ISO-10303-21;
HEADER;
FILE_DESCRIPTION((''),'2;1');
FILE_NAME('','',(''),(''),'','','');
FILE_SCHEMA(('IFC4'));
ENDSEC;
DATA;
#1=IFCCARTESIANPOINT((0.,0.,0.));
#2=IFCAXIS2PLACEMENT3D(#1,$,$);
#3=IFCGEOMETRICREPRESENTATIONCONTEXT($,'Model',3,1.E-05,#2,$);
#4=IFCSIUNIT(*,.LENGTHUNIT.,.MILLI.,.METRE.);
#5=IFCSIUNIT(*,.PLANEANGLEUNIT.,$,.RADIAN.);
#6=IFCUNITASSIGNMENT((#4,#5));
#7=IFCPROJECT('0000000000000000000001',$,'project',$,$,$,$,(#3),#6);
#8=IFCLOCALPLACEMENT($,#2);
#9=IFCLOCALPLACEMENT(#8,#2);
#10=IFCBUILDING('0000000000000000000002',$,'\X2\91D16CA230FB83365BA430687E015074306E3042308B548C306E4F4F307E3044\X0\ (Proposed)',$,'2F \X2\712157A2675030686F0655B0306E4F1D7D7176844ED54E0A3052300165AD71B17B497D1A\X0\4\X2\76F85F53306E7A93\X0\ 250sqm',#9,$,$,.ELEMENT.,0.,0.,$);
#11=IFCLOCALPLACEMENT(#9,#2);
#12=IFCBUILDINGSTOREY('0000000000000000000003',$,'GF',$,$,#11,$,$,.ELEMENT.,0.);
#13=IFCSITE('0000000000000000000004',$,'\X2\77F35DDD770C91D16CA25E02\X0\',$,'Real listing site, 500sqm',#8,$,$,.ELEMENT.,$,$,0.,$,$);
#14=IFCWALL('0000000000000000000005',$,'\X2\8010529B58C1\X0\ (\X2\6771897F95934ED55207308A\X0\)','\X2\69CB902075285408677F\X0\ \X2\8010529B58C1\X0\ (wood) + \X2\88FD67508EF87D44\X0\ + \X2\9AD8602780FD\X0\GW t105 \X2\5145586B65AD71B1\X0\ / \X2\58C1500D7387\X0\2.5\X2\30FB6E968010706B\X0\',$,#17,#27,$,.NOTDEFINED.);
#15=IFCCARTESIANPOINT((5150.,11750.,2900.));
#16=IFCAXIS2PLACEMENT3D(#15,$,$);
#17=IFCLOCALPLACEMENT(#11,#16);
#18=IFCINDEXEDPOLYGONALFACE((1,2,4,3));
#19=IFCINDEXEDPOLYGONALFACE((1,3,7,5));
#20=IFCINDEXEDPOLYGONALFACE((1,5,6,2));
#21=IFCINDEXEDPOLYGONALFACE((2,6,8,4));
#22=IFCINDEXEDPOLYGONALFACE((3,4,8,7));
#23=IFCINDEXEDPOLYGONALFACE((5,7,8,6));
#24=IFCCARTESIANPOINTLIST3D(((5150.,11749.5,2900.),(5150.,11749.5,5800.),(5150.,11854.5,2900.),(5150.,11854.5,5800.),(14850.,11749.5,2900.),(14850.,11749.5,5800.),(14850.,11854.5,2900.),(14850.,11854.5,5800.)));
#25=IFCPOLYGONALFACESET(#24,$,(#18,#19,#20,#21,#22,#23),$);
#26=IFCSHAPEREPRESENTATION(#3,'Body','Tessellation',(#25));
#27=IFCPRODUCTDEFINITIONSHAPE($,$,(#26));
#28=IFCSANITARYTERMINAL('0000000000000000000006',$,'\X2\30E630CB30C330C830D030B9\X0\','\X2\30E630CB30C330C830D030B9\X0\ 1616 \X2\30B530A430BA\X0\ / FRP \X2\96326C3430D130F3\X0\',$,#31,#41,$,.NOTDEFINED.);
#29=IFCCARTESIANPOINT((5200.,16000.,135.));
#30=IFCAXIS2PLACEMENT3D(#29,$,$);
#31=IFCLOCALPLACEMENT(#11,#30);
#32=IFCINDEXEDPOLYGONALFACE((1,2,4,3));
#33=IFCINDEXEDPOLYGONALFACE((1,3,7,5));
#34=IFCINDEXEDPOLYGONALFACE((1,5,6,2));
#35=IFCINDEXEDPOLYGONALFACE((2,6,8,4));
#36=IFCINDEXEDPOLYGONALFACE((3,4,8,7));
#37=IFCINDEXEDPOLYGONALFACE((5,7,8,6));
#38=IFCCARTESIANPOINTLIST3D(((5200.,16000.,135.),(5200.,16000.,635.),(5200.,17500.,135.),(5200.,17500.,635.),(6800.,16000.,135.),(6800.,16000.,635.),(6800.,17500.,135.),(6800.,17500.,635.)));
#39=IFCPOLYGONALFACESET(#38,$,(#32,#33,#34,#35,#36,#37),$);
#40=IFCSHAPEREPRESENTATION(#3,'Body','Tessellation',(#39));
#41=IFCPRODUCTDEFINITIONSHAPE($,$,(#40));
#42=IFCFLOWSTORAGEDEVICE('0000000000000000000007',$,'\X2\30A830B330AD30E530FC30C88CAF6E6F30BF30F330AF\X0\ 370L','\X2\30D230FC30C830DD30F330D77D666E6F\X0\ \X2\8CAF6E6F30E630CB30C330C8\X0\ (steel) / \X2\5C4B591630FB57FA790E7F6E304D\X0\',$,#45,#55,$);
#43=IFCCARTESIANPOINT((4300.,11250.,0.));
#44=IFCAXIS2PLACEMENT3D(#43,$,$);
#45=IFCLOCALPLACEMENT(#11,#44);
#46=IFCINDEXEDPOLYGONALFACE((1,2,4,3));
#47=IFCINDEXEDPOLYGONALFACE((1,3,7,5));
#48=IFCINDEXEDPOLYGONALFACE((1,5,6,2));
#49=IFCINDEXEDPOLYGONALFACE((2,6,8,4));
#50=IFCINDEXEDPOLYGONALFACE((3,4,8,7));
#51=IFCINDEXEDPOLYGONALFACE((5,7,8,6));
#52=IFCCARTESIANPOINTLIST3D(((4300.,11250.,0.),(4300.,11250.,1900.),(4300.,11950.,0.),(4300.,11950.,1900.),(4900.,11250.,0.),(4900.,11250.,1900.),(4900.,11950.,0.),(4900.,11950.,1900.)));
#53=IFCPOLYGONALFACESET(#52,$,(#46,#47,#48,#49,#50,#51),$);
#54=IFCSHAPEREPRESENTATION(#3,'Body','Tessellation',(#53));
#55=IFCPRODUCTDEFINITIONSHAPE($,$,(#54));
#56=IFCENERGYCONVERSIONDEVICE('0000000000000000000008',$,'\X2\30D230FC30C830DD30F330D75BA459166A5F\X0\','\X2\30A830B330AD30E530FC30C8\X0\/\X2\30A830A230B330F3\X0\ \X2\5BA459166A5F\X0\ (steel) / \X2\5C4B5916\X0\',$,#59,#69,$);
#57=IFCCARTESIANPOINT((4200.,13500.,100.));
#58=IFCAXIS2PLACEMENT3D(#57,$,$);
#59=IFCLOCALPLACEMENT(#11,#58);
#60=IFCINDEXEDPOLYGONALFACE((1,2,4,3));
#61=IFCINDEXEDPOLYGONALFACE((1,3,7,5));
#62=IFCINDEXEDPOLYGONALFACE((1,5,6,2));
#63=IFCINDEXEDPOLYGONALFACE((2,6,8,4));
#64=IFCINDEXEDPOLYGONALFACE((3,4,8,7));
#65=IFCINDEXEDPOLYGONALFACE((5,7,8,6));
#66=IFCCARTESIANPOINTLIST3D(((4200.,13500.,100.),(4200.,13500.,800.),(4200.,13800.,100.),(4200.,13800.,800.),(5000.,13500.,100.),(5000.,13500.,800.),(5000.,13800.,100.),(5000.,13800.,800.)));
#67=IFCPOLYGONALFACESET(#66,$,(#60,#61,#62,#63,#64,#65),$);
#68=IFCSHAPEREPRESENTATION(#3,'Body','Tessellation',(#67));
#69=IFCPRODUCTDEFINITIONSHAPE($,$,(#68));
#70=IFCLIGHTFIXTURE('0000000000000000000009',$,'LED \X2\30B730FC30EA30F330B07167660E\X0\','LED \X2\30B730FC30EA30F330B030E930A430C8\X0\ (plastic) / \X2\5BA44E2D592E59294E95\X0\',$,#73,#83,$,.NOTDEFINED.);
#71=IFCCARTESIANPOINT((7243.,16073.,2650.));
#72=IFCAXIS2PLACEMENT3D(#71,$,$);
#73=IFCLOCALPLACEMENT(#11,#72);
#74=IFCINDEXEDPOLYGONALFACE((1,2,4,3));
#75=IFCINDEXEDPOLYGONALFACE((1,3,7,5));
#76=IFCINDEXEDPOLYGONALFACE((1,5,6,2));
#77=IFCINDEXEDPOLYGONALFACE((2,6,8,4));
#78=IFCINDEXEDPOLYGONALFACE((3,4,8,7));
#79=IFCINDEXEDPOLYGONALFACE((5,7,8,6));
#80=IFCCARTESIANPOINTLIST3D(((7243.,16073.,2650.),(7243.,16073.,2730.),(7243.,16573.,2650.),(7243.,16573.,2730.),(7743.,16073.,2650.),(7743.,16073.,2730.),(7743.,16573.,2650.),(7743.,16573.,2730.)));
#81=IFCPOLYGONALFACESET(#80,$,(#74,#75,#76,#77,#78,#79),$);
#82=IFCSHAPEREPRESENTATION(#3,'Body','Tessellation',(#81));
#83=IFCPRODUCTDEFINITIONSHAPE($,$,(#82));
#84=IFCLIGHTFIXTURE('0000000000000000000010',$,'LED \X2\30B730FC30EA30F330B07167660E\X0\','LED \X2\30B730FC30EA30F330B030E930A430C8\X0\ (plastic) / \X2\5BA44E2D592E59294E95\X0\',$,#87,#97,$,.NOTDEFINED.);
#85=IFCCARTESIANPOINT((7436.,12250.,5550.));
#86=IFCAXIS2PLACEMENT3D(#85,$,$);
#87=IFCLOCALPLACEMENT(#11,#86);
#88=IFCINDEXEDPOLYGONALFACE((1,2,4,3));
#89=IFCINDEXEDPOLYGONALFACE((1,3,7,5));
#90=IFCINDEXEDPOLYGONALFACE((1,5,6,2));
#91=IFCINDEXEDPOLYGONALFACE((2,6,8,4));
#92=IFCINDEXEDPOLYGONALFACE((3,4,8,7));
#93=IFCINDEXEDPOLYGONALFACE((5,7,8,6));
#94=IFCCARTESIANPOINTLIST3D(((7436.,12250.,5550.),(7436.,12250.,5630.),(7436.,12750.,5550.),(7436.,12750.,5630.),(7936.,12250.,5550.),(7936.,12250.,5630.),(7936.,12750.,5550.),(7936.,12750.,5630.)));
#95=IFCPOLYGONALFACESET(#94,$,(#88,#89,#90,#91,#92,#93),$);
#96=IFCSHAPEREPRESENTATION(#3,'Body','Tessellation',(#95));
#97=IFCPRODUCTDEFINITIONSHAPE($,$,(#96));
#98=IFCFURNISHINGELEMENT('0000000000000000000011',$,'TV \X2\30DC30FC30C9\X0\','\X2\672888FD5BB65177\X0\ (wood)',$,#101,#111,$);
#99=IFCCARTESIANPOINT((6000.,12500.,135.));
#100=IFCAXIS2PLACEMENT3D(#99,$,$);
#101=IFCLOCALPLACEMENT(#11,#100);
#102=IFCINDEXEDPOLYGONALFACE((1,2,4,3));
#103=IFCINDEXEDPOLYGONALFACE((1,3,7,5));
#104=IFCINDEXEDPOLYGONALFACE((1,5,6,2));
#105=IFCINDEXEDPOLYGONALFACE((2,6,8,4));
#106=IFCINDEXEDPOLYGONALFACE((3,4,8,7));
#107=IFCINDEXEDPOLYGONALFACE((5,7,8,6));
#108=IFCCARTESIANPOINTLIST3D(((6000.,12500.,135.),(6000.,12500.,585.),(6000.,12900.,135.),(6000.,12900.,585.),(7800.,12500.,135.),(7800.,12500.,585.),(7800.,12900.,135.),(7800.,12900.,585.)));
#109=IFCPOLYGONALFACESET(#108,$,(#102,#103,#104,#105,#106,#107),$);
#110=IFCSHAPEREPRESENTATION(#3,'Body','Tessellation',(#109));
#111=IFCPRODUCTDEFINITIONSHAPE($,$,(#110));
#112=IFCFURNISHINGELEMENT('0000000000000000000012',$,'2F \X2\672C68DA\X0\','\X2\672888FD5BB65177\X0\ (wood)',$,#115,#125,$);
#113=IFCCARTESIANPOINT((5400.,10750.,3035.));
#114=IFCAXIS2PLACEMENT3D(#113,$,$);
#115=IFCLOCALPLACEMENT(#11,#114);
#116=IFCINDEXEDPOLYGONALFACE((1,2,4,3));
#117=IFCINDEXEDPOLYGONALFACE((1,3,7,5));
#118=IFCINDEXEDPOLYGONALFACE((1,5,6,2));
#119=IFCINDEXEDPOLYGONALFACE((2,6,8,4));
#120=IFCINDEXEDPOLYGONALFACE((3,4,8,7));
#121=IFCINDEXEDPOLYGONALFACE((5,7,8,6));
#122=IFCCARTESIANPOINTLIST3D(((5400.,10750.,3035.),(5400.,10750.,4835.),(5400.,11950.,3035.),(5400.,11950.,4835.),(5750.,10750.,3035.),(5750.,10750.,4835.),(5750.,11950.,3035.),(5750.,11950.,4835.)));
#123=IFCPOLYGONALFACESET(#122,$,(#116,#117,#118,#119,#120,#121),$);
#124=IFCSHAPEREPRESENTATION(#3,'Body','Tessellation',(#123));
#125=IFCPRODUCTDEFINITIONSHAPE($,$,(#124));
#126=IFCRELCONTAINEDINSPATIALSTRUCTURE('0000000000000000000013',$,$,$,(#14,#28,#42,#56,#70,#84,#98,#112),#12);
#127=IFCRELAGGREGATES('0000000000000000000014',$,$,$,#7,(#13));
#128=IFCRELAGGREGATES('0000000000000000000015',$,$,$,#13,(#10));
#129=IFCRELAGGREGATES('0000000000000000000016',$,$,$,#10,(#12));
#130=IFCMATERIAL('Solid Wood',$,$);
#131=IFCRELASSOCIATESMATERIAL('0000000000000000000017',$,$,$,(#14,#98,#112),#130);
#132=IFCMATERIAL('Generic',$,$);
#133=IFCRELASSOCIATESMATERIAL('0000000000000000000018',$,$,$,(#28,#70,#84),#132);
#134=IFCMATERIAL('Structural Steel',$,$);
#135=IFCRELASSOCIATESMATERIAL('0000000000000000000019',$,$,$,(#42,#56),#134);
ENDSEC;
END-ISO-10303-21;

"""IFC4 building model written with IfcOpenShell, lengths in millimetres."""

from ifc_helpers import new_model, si_unit, frame, frame_2d, origin, place, context, project, spatial, rectangle, extrude, material, element, save


model = new_model("IFC4")

# Units and contexts
model_context = context("Model", 3, precision=1e-05, world=origin())
ifc_project = project(units=[si_unit("LENGTHUNIT", "METRE", prefix="MILLI"), si_unit("PLANEANGLEUNIT", "RADIAN")], contexts=[model_context])

# Site, building, storey
site_placement = place(None, origin())
site = spatial("IfcSite", under=ifc_project, at=site_placement, Name="石川県金沢市", ObjectType="Real listing site, 500sqm", CompositionType="ELEMENT", RefElevation=0.0)
building_placement = place(site_placement, origin())
building = spatial("IfcBuilding", under=site, at=building_placement, Name="金沢・茶室と縁側のある和の住まい (Proposed)", ObjectType="2F 無垢材と漆喰の伝統的仕上げ、断熱等級4相当の窓 250sqm", CompositionType="ELEMENT", ElevationOfRefHeight=0.0, ElevationOfTerrain=0.0)
storey_placement = place(building_placement, origin())
storey = spatial("IfcBuildingStorey", under=building, at=storey_placement, Name="GF", CompositionType="ELEMENT", Elevation=0.0)

# Shared definitions
ifc_material_1 = material(Name="Solid Wood")

# Wall
wall_1_placement = place(storey_placement, frame((5150.0, 11750.0, 2900.0)))
element("IfcWall", 1, at=wall_1_placement, inside=storey, material=ifc_material_1, Name="耐力壁 (東西間仕切り)", Description="構造用合板 耐力壁 (wood) + 製材軸組 + 高性能GW t105 充填断熱 / 壁倍率2.5・準耐火", PredefinedType="NOTDEFINED", context=model_context, shape_type="SweptSolid", body=[
    extrude(rectangle(XDim=9700.0, YDim=105.0, at=frame_2d((4850.0, 52.0))), frame((5150.0, 11750.0, 2900.0)), (0.0, 0.0, 1.0), 2900.0),
])

# Sanitary terminal
ifc_material_2 = material(Name="Generic")
sanitary_terminal_placement = place(storey_placement, frame((5200.0, 16000.0, 135.0)))
element("IfcSanitaryTerminal", 2, at=sanitary_terminal_placement, inside=storey, material=ifc_material_2, Name="ユニットバス", Description="ユニットバス 1616 サイズ / FRP 防水パン", PredefinedType="NOTDEFINED", context=model_context, shape_type="SweptSolid", body=[
    extrude(rectangle(XDim=1600.0, YDim=1500.0, at=frame_2d((800.0, 750.0))), frame((5200.0, 16000.0, 135.0)), (0.0, 0.0, 1.0), 500.0),
])

# Flow storage device
ifc_material_3 = material(Name="Structural Steel")
flow_storage_device_placement = place(storey_placement, frame((4300.0, 11250.0, 0.0)))
element("IfcFlowStorageDevice", 3, at=flow_storage_device_placement, inside=storey, material=ifc_material_3, Name="エコキュート貯湯タンク 370L", Description="ヒートポンプ給湯 貯湯ユニット (steel) / 屋外・基礎置き", context=model_context, shape_type="SweptSolid", body=[
    extrude(rectangle(XDim=600.0, YDim=700.0, at=frame_2d((300.0, 350.0))), frame((4300.0, 11250.0, 0.0)), (0.0, 0.0, 1.0), 1900.0),
])

# Energy conversion device
energy_conversion_device_placement = place(storey_placement, frame((4200.0, 13500.0, 100.0)))
element("IfcEnergyConversionDevice", 4, at=energy_conversion_device_placement, inside=storey, material=ifc_material_3, Name="ヒートポンプ室外機", Description="エコキュート/エアコン 室外機 (steel) / 屋外", context=model_context, shape_type="SweptSolid", body=[
    extrude(rectangle(XDim=800.0, YDim=300.0, at=frame_2d((400.0, 150.0))), frame((4200.0, 13500.0, 100.0)), (0.0, 0.0, 1.0), 700.0),
])

# Light fixtures
light_fixture_1_placement = place(storey_placement, frame((7243.0, 16073.0, 2650.0)))
element("IfcLightFixture", 5, at=light_fixture_1_placement, inside=storey, material=ifc_material_2, Name="LED シーリング照明", Description="LED シーリングライト (plastic) / 室中央天井", PredefinedType="NOTDEFINED", context=model_context, shape_type="SweptSolid", body=[
    extrude(rectangle(XDim=500.0, YDim=500.0, at=frame_2d((250.0, 250.0))), frame((7243.0, 16073.0, 2650.0)), (0.0, 0.0, 1.0), 80.0),
])
light_fixture_2_placement = place(storey_placement, frame((7436.0, 12250.0, 5550.0)))
element("IfcLightFixture", 6, at=light_fixture_2_placement, inside=storey, material=ifc_material_2, Name="LED シーリング照明", Description="LED シーリングライト (plastic) / 室中央天井", PredefinedType="NOTDEFINED", context=model_context, shape_type="SweptSolid", body=[
    extrude(rectangle(XDim=500.0, YDim=500.0, at=frame_2d((250.0, 250.0))), frame((7436.0, 12250.0, 5550.0)), (0.0, 0.0, 1.0), 80.0),
])

# Furnishing elements
furnishing_1_placement = place(storey_placement, frame((6000.0, 12500.0, 135.0)))
element("IfcFurnishingElement", 7, at=furnishing_1_placement, inside=storey, material=ifc_material_1, Name="TV ボード", Description="木製家具 (wood)", context=model_context, shape_type="SweptSolid", body=[
    extrude(rectangle(XDim=1800.0, YDim=400.0, at=frame_2d((900.0, 200.0))), frame((6000.0, 12500.0, 135.0)), (0.0, 0.0, 1.0), 450.0),
])
furnishing_2_placement = place(storey_placement, frame((5400.0, 10750.0, 3035.0)))
element("IfcFurnishingElement", 8, at=furnishing_2_placement, inside=storey, material=ifc_material_1, Name="2F 本棚", Description="木製家具 (wood)", context=model_context, shape_type="SweptSolid", body=[
    extrude(rectangle(XDim=350.0, YDim=1200.0, at=frame_2d((175.0, 600.0))), frame((5400.0, 10750.0, 3035.0)), (0.0, 0.0, 1.0), 1800.0),
])

save(model, "model.ifc")
